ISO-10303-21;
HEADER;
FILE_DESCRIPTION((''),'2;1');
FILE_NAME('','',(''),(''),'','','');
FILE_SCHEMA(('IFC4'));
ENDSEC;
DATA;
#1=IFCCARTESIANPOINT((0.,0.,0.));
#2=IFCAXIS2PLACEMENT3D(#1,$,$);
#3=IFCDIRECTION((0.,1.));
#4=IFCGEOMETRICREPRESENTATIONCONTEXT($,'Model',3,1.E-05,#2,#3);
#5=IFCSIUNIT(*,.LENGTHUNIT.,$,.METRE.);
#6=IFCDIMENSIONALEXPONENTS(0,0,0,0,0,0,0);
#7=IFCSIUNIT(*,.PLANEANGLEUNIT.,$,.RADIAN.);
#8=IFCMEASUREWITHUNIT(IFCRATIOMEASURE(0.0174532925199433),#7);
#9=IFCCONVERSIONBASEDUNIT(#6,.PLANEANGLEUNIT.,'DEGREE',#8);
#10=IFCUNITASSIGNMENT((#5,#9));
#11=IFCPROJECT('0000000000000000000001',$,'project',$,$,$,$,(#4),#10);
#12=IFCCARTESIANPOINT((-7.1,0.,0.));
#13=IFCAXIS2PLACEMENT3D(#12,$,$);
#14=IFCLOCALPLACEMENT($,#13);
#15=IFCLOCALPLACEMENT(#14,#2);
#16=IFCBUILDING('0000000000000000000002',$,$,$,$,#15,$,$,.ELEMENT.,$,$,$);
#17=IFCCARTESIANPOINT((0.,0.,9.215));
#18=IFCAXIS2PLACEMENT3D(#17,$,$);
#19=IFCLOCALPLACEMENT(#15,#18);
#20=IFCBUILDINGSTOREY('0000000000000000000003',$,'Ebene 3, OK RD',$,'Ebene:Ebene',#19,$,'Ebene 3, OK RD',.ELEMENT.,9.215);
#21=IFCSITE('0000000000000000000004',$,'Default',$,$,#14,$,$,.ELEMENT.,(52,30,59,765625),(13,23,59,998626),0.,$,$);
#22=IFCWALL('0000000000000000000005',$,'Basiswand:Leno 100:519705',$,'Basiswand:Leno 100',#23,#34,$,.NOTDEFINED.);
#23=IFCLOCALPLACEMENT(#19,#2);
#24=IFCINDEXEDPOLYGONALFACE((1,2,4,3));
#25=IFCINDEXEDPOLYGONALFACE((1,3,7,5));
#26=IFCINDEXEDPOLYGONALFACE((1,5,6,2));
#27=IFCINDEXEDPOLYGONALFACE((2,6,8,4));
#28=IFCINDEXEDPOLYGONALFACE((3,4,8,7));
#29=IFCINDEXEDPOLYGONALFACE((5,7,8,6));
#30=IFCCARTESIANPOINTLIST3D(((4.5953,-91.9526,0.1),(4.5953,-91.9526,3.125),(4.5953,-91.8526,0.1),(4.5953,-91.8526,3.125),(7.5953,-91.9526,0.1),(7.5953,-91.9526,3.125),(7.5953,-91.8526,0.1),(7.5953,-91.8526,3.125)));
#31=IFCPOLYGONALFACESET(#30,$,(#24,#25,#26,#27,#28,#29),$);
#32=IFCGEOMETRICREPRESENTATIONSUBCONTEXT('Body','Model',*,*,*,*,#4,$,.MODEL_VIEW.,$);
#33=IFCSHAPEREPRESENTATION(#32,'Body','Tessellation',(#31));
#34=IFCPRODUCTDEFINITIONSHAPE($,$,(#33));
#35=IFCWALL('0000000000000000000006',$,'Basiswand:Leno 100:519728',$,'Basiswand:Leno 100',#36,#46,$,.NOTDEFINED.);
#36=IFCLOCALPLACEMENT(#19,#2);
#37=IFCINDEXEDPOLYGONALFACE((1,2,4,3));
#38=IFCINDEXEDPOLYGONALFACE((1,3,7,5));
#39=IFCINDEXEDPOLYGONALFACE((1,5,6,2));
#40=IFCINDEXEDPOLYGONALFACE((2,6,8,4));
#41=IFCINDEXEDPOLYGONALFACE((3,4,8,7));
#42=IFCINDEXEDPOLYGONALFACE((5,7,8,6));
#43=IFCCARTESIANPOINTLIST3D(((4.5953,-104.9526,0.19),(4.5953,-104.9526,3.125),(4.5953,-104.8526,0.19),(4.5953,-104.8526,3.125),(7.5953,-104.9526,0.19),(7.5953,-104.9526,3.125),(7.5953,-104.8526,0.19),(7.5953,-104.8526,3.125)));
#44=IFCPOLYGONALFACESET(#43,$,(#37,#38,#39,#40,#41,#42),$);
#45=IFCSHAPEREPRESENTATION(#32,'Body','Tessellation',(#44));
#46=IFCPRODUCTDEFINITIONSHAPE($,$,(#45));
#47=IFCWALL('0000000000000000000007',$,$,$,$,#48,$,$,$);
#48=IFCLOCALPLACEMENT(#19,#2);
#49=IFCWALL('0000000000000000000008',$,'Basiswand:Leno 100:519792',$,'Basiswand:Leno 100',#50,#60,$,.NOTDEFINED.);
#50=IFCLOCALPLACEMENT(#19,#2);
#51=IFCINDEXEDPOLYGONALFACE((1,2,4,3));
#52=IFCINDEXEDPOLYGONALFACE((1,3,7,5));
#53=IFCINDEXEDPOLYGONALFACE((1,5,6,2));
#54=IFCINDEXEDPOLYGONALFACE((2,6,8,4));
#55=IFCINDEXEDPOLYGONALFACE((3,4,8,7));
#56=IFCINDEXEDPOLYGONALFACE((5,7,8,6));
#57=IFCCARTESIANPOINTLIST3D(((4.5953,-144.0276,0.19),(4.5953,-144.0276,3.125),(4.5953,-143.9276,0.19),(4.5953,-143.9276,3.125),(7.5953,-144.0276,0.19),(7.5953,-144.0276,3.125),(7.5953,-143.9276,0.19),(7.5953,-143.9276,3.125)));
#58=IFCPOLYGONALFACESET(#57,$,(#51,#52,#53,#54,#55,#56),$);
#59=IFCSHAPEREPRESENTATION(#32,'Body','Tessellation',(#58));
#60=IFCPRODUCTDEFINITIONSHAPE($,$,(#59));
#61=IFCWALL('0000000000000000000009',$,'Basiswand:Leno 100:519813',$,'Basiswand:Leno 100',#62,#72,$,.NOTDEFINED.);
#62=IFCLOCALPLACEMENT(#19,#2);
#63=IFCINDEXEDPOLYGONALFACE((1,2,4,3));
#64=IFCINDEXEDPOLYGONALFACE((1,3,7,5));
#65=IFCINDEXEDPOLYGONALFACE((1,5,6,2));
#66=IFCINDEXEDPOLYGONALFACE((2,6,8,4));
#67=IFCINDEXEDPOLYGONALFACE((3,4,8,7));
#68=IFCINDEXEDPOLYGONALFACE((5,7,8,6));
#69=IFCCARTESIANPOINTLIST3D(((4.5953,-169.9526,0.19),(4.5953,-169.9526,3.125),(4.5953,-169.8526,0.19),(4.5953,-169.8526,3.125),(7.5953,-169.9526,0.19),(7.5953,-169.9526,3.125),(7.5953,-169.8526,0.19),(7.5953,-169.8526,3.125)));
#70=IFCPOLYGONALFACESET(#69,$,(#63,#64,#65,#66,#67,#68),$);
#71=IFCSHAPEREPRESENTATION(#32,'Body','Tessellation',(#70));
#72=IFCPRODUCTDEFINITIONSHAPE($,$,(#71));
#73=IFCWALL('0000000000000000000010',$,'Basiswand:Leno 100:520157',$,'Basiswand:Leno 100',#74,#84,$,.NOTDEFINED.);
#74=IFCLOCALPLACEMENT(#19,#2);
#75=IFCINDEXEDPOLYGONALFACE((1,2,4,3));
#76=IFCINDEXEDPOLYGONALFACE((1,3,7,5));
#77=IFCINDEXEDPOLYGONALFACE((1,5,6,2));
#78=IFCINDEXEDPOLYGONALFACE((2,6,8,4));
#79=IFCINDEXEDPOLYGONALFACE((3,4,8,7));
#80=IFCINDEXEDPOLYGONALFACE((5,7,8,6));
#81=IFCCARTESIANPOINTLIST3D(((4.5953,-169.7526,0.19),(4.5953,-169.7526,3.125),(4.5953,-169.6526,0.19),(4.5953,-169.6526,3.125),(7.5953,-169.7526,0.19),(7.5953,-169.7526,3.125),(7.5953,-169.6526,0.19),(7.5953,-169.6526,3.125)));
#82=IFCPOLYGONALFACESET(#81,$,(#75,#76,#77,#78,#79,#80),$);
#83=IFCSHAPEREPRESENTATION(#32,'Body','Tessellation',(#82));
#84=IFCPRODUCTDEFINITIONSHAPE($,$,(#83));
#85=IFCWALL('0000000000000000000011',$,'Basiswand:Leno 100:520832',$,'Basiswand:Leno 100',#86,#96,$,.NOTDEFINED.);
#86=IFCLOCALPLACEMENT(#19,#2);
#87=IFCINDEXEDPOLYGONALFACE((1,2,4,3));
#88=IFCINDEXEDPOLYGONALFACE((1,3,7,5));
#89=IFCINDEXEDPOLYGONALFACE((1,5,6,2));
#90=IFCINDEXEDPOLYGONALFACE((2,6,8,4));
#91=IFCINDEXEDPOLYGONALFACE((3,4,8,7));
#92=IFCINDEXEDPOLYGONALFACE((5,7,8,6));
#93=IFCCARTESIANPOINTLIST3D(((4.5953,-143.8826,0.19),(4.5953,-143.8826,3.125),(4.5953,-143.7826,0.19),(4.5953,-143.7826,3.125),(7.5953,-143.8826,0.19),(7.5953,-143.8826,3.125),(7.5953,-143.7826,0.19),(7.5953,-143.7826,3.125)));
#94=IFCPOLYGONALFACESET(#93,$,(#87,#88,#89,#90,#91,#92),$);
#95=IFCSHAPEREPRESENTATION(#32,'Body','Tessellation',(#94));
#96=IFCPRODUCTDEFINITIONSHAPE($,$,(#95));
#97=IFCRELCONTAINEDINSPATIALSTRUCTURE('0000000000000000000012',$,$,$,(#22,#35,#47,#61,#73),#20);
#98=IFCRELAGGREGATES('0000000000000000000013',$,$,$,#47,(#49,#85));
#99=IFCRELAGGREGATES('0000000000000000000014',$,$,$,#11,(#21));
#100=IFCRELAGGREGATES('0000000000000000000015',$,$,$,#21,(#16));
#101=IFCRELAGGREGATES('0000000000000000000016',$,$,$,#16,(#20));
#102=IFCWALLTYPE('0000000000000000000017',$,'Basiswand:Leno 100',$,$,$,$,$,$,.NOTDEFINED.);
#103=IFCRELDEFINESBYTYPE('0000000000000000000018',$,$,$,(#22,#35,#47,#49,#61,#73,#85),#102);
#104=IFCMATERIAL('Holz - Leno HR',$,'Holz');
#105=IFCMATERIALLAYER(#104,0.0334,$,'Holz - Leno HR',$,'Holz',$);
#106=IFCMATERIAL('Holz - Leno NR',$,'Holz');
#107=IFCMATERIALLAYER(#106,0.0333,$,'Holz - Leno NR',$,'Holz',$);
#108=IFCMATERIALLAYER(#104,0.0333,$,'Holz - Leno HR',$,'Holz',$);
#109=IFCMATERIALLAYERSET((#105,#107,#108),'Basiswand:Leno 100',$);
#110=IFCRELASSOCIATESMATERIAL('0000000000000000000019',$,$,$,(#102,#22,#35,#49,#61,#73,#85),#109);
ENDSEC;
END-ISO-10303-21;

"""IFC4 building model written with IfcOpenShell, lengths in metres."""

from ifc_helpers import new_model, entity, si_unit, converted_unit, direction, frame, origin, place, context, subcontext, project, spatial, indexed_curve, outline, extrude, material, layer, layer_set, type_object, element, aggregate, save


model = new_model("IFC4")

# Units and contexts
model_context = context("Model", 3, precision=1e-05, world=origin(), true_north=direction((0.0, 1.0)))
body_context = subcontext(model_context, "Body", "Model", "MODEL_VIEW")
ifc_project = project(units=[si_unit("LENGTHUNIT", "METRE"), converted_unit("PLANEANGLEUNIT", "DEGREE", entity("IfcRatioMeasure", 0.0174532925199433), si_unit("PLANEANGLEUNIT", "RADIAN"), dimensions=[0, 0, 0, 0, 0, 0, 0])], contexts=[model_context])

# Site, building, storey
site_placement = place(None, frame((-7.1, 0.0, 0.0)))
site = spatial("IfcSite", under=ifc_project, at=site_placement, Name="Default", CompositionType="ELEMENT", RefLatitude=(52, 30, 59, 765625), RefLongitude=(13, 23, 59, 998626), RefElevation=0.0)
building_placement = place(site_placement, origin())
building = spatial("IfcBuilding", under=site, at=building_placement, CompositionType="ELEMENT")
storey_placement = place(building_placement, frame((0.0, 0.0, 9.215)))
storey = spatial("IfcBuildingStorey", under=building, at=storey_placement, Name="Ebene 3, OK RD", ObjectType="Ebene:Ebene", LongName="Ebene 3, OK RD", CompositionType="ELEMENT", Elevation=9.215)

# Shared definitions
ifc_material_1 = material(Name="Holz - Leno HR", Category="Holz")
ifc_material_2 = material(Name="Holz - Leno NR", Category="Holz")

# Walls
ifc_layer_1 = layer(ifc_material_1, 0.0334, Name="Holz - Leno HR", Category="Holz")
ifc_layer_2 = layer(ifc_material_2, 0.0333, Name="Holz - Leno NR", Category="Holz")
ifc_layer_3 = layer(ifc_material_1, 0.0333, Name="Holz - Leno HR", Category="Holz")
ifc_layer_set_1 = layer_set([ifc_layer_1, ifc_layer_2, ifc_layer_3], Name="Basiswand:Leno 100")
wall_type = type_object("IfcWallType", Name="Basiswand:Leno 100", PredefinedType="NOTDEFINED", material=ifc_layer_set_1)
wall_1_placement = place(storey_placement, frame((7.5953, -91.9026, 0.1), z_axis=(0.0, 0.0, 1.0), x_axis=(-1.0, 0.0, 0.0)))
element("IfcWall", 1, at=wall_1_placement, inside=storey, type_object=wall_type, material=ifc_layer_set_1, Name="Basiswand:Leno 100:519705", ObjectType="Basiswand:Leno 100", PredefinedType="NOTDEFINED", context=body_context, shape_type="SweptSolid", body=[
    extrude(outline(indexed_curve([(3.0, 0.05), (0.0, 0.05), (0.0, -0.05), (3.0, -0.05), (3.0, 0.05)], self_intersect=False)), origin(), (0.0, 0.0, 1.0), 3.025),
])
wall_2_placement = place(storey_placement, frame((7.5953, -104.9026, 0.19), z_axis=(0.0, 0.0, 1.0), x_axis=(-1.0, 0.0, 0.0)))
element("IfcWall", 2, at=wall_2_placement, inside=storey, type_object=wall_type, material=ifc_layer_set_1, Name="Basiswand:Leno 100:519728", ObjectType="Basiswand:Leno 100", PredefinedType="NOTDEFINED", context=body_context, shape_type="SweptSolid", body=[
    extrude(outline(indexed_curve([(3.0, 0.05), (0.0, 0.05), (0.0, -0.05), (3.0, -0.05), (3.0, 0.05)], self_intersect=False)), origin(), (0.0, 0.0, 1.0), 2.935),
])
wall_3 = element("IfcWall", 3, inside=storey, type_object=wall_type)
wall_4_placement = place(storey_placement, frame((7.5953, -143.9776, 0.19), z_axis=(0.0, 0.0, 1.0), x_axis=(-1.0, 0.0, 0.0)))
wall_4 = element("IfcWall", 4, at=wall_4_placement, type_object=wall_type, material=ifc_layer_set_1, Name="Basiswand:Leno 100:519792", ObjectType="Basiswand:Leno 100", PredefinedType="NOTDEFINED", context=body_context, shape_type="SweptSolid", body=[
    extrude(outline(indexed_curve([(3.0, 0.05), (0.0, 0.05), (0.0, -0.05), (3.0, -0.05), (3.0, 0.05)], self_intersect=False)), origin(), (0.0, 0.0, 1.0), 2.935),
])
for number, where, z_axis, x_axis, name in (
    (5, (7.5953, -169.9026, 0.19), (0.0, 0.0, 1.0), (-1.0, 0.0, 0.0), "Basiswand:Leno 100:519813"),
    (6, (7.5953, -169.7026, 0.19), (0.0, 0.0, 1.0), (-1.0, 0.0, 0.0), "Basiswand:Leno 100:520157"),
):
    element("IfcWall", number, at=place(storey_placement, frame(where, z_axis=z_axis, x_axis=x_axis)), inside=storey, type_object=wall_type, material=ifc_layer_set_1, Name=name, ObjectType="Basiswand:Leno 100", PredefinedType="NOTDEFINED", context=body_context, shape_type="SweptSolid", body=[
        extrude(outline(indexed_curve([(3.0, 0.05), (0.0, 0.05), (0.0, -0.05), (3.0, -0.05), (3.0, 0.05)], self_intersect=False)), origin(), (0.0, 0.0, 1.0), 2.935),
    ])

# Wall
wall_5_placement = place(storey_placement, frame((7.5953, -143.8326, 0.19), z_axis=(0.0, 0.0, 1.0), x_axis=(-1.0, 0.0, 0.0)))
wall_5 = element("IfcWall", 7, at=wall_5_placement, type_object=wall_type, material=ifc_layer_set_1, Name="Basiswand:Leno 100:520832", ObjectType="Basiswand:Leno 100", PredefinedType="NOTDEFINED", context=body_context, shape_type="SweptSolid", body=[
    extrude(outline(indexed_curve([(3.0, 0.05), (0.0, 0.05), (0.0, -0.05), (3.0, -0.05), (3.0, 0.05)], self_intersect=False)), origin(), (0.0, 0.0, 1.0), 2.935),
])
aggregate(wall_3, [wall_4, wall_5])

save(model, "model.ifc")
